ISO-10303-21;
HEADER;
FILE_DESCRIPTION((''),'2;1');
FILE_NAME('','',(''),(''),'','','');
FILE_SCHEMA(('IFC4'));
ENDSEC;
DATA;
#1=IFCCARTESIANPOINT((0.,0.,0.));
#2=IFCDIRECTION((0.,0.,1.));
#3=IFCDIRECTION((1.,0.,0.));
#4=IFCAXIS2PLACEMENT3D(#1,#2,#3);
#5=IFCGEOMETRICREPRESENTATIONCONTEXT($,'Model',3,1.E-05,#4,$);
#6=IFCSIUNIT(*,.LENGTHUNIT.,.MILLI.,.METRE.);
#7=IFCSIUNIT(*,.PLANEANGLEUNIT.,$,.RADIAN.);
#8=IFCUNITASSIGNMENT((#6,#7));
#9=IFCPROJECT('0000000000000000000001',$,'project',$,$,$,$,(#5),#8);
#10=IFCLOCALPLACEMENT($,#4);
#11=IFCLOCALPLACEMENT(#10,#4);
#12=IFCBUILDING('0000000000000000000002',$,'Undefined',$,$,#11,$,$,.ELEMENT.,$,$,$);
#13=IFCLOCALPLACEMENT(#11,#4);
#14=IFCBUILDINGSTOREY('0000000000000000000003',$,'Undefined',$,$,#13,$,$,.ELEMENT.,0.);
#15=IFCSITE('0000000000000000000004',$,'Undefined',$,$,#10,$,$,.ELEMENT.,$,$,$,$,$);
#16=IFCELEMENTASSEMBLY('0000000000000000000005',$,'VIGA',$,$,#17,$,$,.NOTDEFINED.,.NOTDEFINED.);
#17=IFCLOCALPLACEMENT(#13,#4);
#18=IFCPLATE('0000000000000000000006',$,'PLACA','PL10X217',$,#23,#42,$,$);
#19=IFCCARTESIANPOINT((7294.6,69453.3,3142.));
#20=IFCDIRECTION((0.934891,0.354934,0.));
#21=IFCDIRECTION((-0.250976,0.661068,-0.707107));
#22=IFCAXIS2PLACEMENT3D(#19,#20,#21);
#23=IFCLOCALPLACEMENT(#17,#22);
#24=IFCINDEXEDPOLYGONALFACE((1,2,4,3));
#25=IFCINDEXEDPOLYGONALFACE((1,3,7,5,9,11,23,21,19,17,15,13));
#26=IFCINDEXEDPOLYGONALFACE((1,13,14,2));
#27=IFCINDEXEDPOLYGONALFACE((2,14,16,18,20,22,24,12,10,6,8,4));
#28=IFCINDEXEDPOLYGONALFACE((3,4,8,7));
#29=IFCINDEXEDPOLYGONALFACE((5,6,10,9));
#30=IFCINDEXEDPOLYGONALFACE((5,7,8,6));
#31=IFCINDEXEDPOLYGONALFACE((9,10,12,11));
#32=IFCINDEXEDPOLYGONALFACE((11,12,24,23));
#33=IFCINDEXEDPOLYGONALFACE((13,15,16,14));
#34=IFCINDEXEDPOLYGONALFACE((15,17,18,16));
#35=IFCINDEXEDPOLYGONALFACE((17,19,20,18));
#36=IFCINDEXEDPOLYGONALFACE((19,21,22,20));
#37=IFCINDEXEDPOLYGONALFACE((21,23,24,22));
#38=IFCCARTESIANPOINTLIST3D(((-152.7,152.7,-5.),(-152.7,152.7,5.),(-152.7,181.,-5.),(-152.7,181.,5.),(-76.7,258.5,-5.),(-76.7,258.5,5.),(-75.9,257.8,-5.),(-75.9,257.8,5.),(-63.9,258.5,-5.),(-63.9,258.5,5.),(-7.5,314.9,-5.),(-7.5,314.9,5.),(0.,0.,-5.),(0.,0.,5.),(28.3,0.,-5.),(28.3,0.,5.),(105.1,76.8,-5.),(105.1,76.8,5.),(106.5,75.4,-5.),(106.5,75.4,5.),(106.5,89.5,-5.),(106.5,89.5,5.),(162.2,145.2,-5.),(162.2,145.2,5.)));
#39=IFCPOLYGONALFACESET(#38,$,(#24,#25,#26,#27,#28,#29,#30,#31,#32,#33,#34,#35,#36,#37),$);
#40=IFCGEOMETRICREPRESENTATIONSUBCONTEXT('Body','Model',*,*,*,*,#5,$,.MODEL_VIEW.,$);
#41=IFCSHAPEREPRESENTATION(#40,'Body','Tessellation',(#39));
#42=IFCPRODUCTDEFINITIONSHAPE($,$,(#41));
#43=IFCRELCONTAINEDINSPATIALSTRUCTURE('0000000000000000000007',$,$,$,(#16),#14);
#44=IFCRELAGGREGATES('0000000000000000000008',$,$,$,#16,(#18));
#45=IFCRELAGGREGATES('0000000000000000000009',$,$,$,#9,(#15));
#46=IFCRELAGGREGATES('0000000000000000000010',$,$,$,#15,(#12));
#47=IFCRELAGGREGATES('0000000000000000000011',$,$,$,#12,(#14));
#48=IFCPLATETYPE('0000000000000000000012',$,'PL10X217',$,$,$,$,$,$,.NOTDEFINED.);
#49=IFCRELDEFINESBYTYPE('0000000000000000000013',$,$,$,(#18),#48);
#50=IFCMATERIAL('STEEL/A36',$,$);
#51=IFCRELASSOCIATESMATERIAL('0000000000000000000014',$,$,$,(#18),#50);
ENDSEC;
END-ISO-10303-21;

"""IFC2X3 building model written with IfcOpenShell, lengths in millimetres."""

from ifc_helpers import new_model, si_unit, frame, origin_with_axes, place, context, subcontext, project, spatial, polyline, outline, extrude, material, type_object, element, aggregate, save


model = new_model("IFC2X3")

# Units and contexts
model_context = context("Model", 3, precision=1e-05, world=origin_with_axes())
body_context = subcontext(model_context, "Body", "Model", "MODEL_VIEW")
ifc_project = project(units=[si_unit("LENGTHUNIT", "METRE", prefix="MILLI"), si_unit("PLANEANGLEUNIT", "RADIAN")], contexts=[model_context])

# Site, building, storey
site_placement = place(None, origin_with_axes())
site = spatial("IfcSite", under=ifc_project, at=site_placement, Name="Undefined", CompositionType="ELEMENT")
building_placement = place(site_placement, origin_with_axes())
building = spatial("IfcBuilding", under=site, at=building_placement, Name="Undefined", CompositionType="ELEMENT")
storey_placement = place(building_placement, origin_with_axes())
storey = spatial("IfcBuildingStorey", under=building, at=storey_placement, Name="Undefined", CompositionType="ELEMENT", Elevation=0.0)

# Shared definitions
ifc_material_1 = material(Name="STEEL/A36")

# Element assembly, plate
assembly_1_placement = place(storey_placement, origin_with_axes())
assembly_1 = element("IfcElementAssembly", 1, at=assembly_1_placement, inside=storey, Name="VIGA", AssemblyPlace="NOTDEFINED", PredefinedType="NOTDEFINED")
plate_type_1 = type_object("IfcPlateType", Name="PL10X217", PredefinedType="NOTDEFINED")
plate_1_placement = place(assembly_1_placement, frame((7294.6, 69453.3, 3142.0), z_axis=(0.934891, 0.354934, 0.0), x_axis=(-0.250976, 0.661068, -0.707107)))
plate_1 = element("IfcPlate", 2, at=plate_1_placement, type_object=plate_type_1, material=ifc_material_1, Name="PLACA", Description="PL10X217", context=body_context, shape_type="SweptSolid", body=[
    extrude(outline(polyline([(0.0, 0.0), (28.3, 0.0), (105.1, 76.8), (106.5, 75.4), (106.5, 89.5), (162.2, 145.2), (-7.5, 314.9), (-63.9, 258.5), (-76.7, 258.5), (-75.9, 257.8), (-152.7, 181.0), (-152.7, 152.7), (0.0, 0.0)])), frame((0.0, 0.0, -5.0), z_axis=(0.0, 0.0, 1.0), x_axis=(1.0, 0.0, 0.0)), (0.0, 0.0, 1.0), 10.0),
])
aggregate(assembly_1, [plate_1])

save(model, "model.ifc")
